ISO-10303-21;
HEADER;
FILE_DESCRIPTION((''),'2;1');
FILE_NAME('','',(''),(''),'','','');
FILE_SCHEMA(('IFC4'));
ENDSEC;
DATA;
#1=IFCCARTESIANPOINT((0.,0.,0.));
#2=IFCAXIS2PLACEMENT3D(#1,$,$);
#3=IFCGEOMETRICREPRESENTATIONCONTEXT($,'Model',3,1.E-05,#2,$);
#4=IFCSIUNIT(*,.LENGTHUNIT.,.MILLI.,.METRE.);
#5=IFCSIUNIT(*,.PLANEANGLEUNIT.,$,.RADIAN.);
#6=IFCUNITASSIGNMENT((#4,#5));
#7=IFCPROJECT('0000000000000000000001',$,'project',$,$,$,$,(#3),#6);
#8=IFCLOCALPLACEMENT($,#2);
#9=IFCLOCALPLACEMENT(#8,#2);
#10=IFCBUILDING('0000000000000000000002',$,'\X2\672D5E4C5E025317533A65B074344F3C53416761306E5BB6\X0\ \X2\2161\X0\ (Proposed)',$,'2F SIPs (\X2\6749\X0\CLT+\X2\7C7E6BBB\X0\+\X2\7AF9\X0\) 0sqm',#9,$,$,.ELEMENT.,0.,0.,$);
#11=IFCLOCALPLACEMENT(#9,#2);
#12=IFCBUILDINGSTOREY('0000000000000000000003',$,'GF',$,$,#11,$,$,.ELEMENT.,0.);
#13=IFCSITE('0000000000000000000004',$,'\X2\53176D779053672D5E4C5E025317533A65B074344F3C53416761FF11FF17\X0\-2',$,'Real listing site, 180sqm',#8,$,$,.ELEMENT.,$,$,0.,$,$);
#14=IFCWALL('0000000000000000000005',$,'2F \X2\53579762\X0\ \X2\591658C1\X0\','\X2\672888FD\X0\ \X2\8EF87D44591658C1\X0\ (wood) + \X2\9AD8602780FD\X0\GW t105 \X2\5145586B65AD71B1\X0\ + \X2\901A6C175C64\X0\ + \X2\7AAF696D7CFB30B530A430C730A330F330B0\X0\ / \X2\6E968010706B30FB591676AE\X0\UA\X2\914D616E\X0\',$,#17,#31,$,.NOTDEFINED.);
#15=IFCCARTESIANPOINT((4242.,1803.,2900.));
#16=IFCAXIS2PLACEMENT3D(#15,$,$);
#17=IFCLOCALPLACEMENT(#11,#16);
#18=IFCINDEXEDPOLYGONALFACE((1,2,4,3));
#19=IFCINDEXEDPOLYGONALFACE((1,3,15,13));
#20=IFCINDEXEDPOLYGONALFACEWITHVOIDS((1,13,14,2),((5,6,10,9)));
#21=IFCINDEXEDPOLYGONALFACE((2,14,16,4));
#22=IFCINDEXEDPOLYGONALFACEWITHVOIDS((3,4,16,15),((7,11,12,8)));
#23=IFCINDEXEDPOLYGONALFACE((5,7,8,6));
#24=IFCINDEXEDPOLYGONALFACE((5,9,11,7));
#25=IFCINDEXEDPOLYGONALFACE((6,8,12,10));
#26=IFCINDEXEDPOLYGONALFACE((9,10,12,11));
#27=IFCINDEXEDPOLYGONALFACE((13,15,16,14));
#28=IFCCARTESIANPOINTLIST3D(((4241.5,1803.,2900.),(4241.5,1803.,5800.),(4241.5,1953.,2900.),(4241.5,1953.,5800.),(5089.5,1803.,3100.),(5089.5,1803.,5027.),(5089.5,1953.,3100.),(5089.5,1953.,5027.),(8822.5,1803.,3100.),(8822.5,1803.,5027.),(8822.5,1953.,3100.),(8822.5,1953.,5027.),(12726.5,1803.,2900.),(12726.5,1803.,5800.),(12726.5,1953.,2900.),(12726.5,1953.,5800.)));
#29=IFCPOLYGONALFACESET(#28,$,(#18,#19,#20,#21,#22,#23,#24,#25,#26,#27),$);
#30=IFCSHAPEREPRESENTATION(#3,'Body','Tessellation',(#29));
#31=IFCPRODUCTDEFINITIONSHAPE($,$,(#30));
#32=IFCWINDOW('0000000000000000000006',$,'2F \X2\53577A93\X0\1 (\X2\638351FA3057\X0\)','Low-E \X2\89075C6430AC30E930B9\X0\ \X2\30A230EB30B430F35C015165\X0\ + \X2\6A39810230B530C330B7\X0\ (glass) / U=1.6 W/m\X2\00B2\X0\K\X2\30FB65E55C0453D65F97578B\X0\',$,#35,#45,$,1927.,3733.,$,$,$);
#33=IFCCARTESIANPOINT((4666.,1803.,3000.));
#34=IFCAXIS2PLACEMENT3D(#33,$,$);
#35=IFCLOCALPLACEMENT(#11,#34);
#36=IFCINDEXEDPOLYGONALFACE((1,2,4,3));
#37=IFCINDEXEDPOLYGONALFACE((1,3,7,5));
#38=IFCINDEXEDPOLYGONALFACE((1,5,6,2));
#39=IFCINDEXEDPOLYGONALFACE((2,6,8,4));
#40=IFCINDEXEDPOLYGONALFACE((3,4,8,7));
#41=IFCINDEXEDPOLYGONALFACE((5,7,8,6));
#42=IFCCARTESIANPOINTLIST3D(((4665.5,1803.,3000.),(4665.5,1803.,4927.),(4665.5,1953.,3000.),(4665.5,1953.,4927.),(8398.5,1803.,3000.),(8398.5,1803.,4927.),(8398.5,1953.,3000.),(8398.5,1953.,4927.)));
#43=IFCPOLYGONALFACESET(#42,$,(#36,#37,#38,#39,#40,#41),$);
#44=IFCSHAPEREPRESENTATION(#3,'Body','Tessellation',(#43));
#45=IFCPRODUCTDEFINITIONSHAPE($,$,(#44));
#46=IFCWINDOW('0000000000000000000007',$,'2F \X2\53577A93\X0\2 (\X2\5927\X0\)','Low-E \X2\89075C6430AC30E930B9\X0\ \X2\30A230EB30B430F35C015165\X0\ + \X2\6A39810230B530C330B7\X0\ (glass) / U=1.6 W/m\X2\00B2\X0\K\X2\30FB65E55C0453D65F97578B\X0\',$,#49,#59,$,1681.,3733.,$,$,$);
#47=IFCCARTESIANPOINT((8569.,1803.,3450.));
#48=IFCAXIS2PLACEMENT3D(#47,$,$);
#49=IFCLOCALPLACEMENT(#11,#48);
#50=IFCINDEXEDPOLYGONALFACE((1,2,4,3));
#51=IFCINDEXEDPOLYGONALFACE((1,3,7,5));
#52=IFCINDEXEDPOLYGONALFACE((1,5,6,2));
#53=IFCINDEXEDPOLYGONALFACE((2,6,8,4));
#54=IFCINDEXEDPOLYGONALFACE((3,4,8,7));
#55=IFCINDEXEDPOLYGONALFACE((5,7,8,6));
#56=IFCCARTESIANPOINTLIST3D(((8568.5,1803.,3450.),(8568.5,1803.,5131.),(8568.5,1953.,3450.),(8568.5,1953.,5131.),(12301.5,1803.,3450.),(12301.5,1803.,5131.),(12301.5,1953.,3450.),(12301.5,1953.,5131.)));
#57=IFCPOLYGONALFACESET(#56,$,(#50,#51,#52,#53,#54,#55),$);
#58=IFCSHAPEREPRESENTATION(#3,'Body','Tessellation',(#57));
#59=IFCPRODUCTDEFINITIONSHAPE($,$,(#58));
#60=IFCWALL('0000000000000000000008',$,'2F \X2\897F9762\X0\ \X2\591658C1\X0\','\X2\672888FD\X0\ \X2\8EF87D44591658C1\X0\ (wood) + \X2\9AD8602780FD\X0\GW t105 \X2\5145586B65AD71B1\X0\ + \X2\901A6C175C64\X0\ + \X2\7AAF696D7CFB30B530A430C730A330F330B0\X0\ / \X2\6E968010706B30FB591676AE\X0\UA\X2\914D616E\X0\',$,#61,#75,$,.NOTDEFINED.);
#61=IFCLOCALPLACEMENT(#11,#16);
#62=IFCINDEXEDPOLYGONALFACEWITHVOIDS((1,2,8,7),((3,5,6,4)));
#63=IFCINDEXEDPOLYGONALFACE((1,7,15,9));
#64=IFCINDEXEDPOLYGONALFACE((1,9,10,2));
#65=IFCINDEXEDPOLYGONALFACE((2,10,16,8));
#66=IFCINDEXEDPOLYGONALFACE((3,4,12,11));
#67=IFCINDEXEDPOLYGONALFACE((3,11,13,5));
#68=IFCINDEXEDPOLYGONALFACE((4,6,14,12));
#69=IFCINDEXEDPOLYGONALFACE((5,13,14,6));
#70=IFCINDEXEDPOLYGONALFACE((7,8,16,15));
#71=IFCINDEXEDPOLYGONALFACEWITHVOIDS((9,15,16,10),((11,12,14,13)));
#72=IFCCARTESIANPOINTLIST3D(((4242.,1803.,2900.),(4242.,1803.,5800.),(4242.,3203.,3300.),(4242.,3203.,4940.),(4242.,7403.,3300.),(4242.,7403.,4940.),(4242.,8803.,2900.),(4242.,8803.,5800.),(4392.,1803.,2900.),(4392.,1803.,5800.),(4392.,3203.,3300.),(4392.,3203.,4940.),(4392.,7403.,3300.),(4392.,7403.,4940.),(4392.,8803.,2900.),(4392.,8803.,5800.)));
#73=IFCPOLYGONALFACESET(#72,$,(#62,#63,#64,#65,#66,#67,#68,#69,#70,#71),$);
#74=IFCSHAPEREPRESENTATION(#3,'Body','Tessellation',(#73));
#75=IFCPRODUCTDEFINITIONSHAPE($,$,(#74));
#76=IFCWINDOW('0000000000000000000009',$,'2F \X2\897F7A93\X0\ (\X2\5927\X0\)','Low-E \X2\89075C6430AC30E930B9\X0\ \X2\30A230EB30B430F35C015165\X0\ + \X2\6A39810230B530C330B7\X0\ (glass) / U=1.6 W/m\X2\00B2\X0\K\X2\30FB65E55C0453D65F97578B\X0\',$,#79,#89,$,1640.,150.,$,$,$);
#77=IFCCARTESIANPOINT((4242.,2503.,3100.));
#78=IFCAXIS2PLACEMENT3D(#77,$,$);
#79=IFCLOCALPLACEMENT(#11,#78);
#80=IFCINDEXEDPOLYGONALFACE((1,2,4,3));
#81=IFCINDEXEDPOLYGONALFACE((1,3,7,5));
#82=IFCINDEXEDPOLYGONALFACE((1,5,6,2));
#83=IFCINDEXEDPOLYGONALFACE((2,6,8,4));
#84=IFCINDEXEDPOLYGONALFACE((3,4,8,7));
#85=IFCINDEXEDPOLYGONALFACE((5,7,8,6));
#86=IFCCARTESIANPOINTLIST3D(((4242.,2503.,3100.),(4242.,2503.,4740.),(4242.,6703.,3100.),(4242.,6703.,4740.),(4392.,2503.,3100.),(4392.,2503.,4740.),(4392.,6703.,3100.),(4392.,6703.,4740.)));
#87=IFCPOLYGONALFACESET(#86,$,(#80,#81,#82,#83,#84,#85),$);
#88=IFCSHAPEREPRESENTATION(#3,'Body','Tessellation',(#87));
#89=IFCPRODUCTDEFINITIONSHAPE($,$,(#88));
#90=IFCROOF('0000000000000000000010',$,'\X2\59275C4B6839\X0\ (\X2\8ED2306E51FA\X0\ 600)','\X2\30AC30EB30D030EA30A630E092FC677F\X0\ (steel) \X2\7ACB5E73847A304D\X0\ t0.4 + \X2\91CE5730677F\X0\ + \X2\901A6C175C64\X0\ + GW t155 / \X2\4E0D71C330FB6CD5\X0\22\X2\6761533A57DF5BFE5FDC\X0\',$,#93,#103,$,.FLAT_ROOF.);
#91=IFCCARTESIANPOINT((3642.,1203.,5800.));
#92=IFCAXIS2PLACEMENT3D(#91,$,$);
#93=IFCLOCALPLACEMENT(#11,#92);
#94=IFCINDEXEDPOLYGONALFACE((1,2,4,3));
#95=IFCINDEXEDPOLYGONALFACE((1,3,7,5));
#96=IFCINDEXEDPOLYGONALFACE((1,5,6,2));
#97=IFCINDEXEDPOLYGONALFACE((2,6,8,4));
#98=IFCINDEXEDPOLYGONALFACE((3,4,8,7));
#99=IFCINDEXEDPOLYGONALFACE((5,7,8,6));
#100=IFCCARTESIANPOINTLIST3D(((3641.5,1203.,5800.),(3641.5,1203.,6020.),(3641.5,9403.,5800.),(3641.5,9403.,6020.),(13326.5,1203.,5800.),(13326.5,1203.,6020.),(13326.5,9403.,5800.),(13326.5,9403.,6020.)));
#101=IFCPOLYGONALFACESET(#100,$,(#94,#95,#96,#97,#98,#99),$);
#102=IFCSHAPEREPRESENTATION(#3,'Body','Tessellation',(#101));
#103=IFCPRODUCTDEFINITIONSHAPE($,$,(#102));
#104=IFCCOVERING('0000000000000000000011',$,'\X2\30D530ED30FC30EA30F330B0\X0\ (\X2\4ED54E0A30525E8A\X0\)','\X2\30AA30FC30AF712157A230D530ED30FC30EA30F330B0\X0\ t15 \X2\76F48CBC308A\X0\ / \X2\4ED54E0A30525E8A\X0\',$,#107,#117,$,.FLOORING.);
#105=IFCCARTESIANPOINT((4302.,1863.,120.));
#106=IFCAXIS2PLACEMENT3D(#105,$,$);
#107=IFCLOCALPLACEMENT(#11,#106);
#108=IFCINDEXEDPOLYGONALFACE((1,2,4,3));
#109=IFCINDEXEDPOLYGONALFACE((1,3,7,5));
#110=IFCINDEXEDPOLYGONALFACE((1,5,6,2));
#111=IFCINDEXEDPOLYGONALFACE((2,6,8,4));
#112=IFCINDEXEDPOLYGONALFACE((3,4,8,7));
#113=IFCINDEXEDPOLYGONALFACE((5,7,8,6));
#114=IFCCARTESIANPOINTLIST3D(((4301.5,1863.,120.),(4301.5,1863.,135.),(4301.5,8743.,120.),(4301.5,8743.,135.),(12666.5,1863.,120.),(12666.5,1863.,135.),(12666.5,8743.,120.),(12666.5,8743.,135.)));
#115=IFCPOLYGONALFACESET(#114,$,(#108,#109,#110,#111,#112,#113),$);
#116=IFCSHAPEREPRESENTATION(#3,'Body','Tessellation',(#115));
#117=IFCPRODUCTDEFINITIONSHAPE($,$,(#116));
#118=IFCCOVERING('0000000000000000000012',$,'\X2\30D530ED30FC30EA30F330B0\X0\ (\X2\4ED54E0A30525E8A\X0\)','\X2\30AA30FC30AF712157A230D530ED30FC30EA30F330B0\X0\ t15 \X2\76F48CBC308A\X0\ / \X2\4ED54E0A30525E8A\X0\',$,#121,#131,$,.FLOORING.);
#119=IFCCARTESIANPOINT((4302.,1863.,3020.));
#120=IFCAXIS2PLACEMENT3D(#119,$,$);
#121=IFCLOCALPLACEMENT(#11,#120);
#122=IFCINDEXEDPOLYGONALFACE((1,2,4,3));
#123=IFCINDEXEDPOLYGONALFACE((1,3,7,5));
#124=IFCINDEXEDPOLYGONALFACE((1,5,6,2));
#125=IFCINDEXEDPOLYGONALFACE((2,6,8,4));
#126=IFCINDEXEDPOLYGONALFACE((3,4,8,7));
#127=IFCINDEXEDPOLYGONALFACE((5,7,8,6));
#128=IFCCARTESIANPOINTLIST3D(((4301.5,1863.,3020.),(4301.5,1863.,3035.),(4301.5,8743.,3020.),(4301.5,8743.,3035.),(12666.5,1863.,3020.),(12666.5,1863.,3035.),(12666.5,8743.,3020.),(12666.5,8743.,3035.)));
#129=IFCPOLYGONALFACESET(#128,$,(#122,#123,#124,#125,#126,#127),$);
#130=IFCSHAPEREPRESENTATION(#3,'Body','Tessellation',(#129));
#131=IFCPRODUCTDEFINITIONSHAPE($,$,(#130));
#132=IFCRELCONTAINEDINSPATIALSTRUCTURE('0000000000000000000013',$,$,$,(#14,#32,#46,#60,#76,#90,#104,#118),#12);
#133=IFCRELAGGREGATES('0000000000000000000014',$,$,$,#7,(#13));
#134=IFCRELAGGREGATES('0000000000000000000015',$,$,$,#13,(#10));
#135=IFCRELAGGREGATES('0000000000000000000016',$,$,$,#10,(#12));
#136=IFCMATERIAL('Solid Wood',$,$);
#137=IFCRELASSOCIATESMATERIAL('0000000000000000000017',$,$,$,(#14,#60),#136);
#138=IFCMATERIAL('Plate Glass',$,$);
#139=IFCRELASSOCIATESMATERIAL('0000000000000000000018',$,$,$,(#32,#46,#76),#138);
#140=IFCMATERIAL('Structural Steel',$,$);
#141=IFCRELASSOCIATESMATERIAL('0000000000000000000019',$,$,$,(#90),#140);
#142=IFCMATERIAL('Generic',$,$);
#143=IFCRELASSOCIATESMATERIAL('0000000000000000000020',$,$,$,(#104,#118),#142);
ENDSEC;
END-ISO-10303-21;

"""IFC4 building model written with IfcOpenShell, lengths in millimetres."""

from ifc_helpers import new_model, si_unit, frame, frame_2d, origin, place, context, project, spatial, rectangle, extrude, material, element, fill, save


model = new_model("IFC4")

# Units and contexts
model_context = context("Model", 3, precision=1e-05, world=origin())
ifc_project = project(units=[si_unit("LENGTHUNIT", "METRE", prefix="MILLI"), si_unit("PLANEANGLEUNIT", "RADIAN")], contexts=[model_context])

# Site, building, storey
site_placement = place(None, origin())
site = spatial("IfcSite", under=ifc_project, at=site_placement, Name="北海道札幌市北区新琴似十条１７-2", ObjectType="Real listing site, 180sqm", CompositionType="ELEMENT", RefElevation=0.0)
building_placement = place(site_placement, origin())
building = spatial("IfcBuilding", under=site, at=building_placement, Name="札幌市北区新琴似十条の家 Ⅱ (Proposed)", ObjectType="2F SIPs (杉CLT+籾殻+竹) 0sqm", CompositionType="ELEMENT", ElevationOfRefHeight=0.0, ElevationOfTerrain=0.0)
storey_placement = place(building_placement, origin())
storey = spatial("IfcBuildingStorey", under=building, at=storey_placement, Name="GF", CompositionType="ELEMENT", Elevation=0.0)

# Shared definitions
ifc_material_1 = material(Name="Solid Wood")

# Shared definitions
ifc_material_2 = material(Name="Plate Glass")

# Wall, openings, windows
wall_1_placement = place(storey_placement, frame((4242.0, 1803.0, 2900.0)))
wall_1 = element("IfcWall", 1, at=wall_1_placement, inside=storey, material=ifc_material_1, Name="2F 南面 外壁", Description="木製 軸組外壁 (wood) + 高性能GW t105 充填断熱 + 通気層 + 窯業系サイディング / 準耐火・外皮UA配慮", PredefinedType="NOTDEFINED", context=model_context, shape_type="SweptSolid", body=[
    extrude(rectangle(XDim=8485.0, YDim=150.0, at=frame_2d((4242.0, 75.0))), frame((4242.0, 1803.0, 2900.0)), (0.0, 0.0, 1.0), 2900.0),
])
opening_1_placement = place(storey_placement, frame((4666.0, 1803.0, 3000.0)))
opening_1 = element("IfcOpeningElement", 2, at=opening_1_placement, cuts=wall_1, PredefinedType="NOTDEFINED", context=model_context, shape_type="SweptSolid", body=[
    extrude(rectangle(XDim=3733.0, YDim=150.0, at=frame_2d((1866.0, 75.0))), frame((4666.0, 1803.0, 3000.0)), (0.0, 0.0, 1.0), 1927.0),
])
opening_2_placement = place(storey_placement, frame((8569.0, 1803.0, 3450.0)))
opening_2 = element("IfcOpeningElement", 3, at=opening_2_placement, cuts=wall_1, PredefinedType="NOTDEFINED", context=model_context, shape_type="SweptSolid", body=[
    extrude(rectangle(XDim=3733.0, YDim=150.0, at=frame_2d((1866.0, 75.0))), frame((8569.0, 1803.0, 3450.0)), (0.0, 0.0, 1.0), 1681.0),
])
window_1_placement = place(storey_placement, frame((4666.0, 1803.0, 3000.0)))
window_1 = element("IfcWindow", 4, at=window_1_placement, inside=storey, material=ifc_material_2, Name="2F 南窓1 (掃出し)", Description="Low-E 複層ガラス アルゴン封入 + 樹脂サッシ (glass) / U=1.6 W/m²K・日射取得型", OverallHeight=1927.0, OverallWidth=3733.0, context=model_context, shape_type="SweptSolid", body=[
    extrude(rectangle(XDim=3733.0, YDim=150.0, at=frame_2d((1866.0, 75.0))), frame((4666.0, 1803.0, 3000.0)), (0.0, 0.0, 1.0), 1927.0),
])
fill(opening_1, window_1)
window_2_placement = place(storey_placement, frame((8569.0, 1803.0, 3450.0)))
window_2 = element("IfcWindow", 5, at=window_2_placement, inside=storey, material=ifc_material_2, Name="2F 南窓2 (大)", Description="Low-E 複層ガラス アルゴン封入 + 樹脂サッシ (glass) / U=1.6 W/m²K・日射取得型", OverallHeight=1681.0, OverallWidth=3733.0, context=model_context, shape_type="SweptSolid", body=[
    extrude(rectangle(XDim=3733.0, YDim=150.0, at=frame_2d((1866.0, 75.0))), frame((8569.0, 1803.0, 3450.0)), (0.0, 0.0, 1.0), 1681.0),
])
fill(opening_2, window_2)

# Wall, opening, window
wall_2_placement = place(storey_placement, frame((4242.0, 1803.0, 2900.0)))
wall_2 = element("IfcWall", 6, at=wall_2_placement, inside=storey, material=ifc_material_1, Name="2F 西面 外壁", Description="木製 軸組外壁 (wood) + 高性能GW t105 充填断熱 + 通気層 + 窯業系サイディング / 準耐火・外皮UA配慮", PredefinedType="NOTDEFINED", context=model_context, shape_type="SweptSolid", body=[
    extrude(rectangle(XDim=150.0, YDim=7000.0, at=frame_2d((75.0, 3500.0))), frame((4242.0, 1803.0, 2900.0)), (0.0, 0.0, 1.0), 2900.0),
])
opening_3_placement = place(storey_placement, frame((4242.0, 2503.0, 3100.0)))
opening_3 = element("IfcOpeningElement", 7, at=opening_3_placement, cuts=wall_2, PredefinedType="NOTDEFINED", context=model_context, shape_type="SweptSolid", body=[
    extrude(rectangle(XDim=150.0, YDim=4200.0, at=frame_2d((75.0, 2100.0))), frame((4242.0, 2503.0, 3100.0)), (0.0, 0.0, 1.0), 1640.0),
])
window_3_placement = place(storey_placement, frame((4242.0, 2503.0, 3100.0)))
window_3 = element("IfcWindow", 8, at=window_3_placement, inside=storey, material=ifc_material_2, Name="2F 西窓 (大)", Description="Low-E 複層ガラス アルゴン封入 + 樹脂サッシ (glass) / U=1.6 W/m²K・日射取得型", OverallHeight=1640.0, OverallWidth=150.0, context=model_context, shape_type="SweptSolid", body=[
    extrude(rectangle(XDim=150.0, YDim=4200.0, at=frame_2d((75.0, 2100.0))), frame((4242.0, 2503.0, 3100.0)), (0.0, 0.0, 1.0), 1640.0),
])
fill(opening_3, window_3)

# Roof
ifc_material_3 = material(Name="Structural Steel")
roof_placement = place(storey_placement, frame((3642.0, 1203.0, 5800.0)))
element("IfcRoof", 9, at=roof_placement, inside=storey, material=ifc_material_3, Name="大屋根 (軒の出 600)", Description="ガルバリウム鋼板 (steel) 立平葺き t0.4 + 野地板 + 通気層 + GW t155 / 不燃・法22条区域対応", PredefinedType="FLAT_ROOF", context=model_context, shape_type="SweptSolid", body=[
    extrude(rectangle(XDim=9685.0, YDim=8200.0, at=frame_2d((4842.0, 4100.0))), frame((3642.0, 1203.0, 5800.0)), (0.0, 0.0, 1.0), 220.0),
])

# Coverings
ifc_material_4 = material(Name="Generic")
covering_1_placement = place(storey_placement, frame((4302.0, 1863.0, 120.0)))
element("IfcCovering", 10, at=covering_1_placement, inside=storey, material=ifc_material_4, Name="フローリング (仕上げ床)", Description="オーク無垢フローリング t15 直貼り / 仕上げ床", PredefinedType="FLOORING", context=model_context, shape_type="SweptSolid", body=[
    extrude(rectangle(XDim=8365.0, YDim=6880.0, at=frame_2d((4182.0, 3440.0))), frame((4302.0, 1863.0, 120.0)), (0.0, 0.0, 1.0), 15.0),
])
covering_2_placement = place(storey_placement, frame((4302.0, 1863.0, 3020.0)))
element("IfcCovering", 11, at=covering_2_placement, inside=storey, material=ifc_material_4, Name="フローリング (仕上げ床)", Description="オーク無垢フローリング t15 直貼り / 仕上げ床", PredefinedType="FLOORING", context=model_context, shape_type="SweptSolid", body=[
    extrude(rectangle(XDim=8365.0, YDim=6880.0, at=frame_2d((4182.0, 3440.0))), frame((4302.0, 1863.0, 3020.0)), (0.0, 0.0, 1.0), 15.0),
])

save(model, "model.ifc")
